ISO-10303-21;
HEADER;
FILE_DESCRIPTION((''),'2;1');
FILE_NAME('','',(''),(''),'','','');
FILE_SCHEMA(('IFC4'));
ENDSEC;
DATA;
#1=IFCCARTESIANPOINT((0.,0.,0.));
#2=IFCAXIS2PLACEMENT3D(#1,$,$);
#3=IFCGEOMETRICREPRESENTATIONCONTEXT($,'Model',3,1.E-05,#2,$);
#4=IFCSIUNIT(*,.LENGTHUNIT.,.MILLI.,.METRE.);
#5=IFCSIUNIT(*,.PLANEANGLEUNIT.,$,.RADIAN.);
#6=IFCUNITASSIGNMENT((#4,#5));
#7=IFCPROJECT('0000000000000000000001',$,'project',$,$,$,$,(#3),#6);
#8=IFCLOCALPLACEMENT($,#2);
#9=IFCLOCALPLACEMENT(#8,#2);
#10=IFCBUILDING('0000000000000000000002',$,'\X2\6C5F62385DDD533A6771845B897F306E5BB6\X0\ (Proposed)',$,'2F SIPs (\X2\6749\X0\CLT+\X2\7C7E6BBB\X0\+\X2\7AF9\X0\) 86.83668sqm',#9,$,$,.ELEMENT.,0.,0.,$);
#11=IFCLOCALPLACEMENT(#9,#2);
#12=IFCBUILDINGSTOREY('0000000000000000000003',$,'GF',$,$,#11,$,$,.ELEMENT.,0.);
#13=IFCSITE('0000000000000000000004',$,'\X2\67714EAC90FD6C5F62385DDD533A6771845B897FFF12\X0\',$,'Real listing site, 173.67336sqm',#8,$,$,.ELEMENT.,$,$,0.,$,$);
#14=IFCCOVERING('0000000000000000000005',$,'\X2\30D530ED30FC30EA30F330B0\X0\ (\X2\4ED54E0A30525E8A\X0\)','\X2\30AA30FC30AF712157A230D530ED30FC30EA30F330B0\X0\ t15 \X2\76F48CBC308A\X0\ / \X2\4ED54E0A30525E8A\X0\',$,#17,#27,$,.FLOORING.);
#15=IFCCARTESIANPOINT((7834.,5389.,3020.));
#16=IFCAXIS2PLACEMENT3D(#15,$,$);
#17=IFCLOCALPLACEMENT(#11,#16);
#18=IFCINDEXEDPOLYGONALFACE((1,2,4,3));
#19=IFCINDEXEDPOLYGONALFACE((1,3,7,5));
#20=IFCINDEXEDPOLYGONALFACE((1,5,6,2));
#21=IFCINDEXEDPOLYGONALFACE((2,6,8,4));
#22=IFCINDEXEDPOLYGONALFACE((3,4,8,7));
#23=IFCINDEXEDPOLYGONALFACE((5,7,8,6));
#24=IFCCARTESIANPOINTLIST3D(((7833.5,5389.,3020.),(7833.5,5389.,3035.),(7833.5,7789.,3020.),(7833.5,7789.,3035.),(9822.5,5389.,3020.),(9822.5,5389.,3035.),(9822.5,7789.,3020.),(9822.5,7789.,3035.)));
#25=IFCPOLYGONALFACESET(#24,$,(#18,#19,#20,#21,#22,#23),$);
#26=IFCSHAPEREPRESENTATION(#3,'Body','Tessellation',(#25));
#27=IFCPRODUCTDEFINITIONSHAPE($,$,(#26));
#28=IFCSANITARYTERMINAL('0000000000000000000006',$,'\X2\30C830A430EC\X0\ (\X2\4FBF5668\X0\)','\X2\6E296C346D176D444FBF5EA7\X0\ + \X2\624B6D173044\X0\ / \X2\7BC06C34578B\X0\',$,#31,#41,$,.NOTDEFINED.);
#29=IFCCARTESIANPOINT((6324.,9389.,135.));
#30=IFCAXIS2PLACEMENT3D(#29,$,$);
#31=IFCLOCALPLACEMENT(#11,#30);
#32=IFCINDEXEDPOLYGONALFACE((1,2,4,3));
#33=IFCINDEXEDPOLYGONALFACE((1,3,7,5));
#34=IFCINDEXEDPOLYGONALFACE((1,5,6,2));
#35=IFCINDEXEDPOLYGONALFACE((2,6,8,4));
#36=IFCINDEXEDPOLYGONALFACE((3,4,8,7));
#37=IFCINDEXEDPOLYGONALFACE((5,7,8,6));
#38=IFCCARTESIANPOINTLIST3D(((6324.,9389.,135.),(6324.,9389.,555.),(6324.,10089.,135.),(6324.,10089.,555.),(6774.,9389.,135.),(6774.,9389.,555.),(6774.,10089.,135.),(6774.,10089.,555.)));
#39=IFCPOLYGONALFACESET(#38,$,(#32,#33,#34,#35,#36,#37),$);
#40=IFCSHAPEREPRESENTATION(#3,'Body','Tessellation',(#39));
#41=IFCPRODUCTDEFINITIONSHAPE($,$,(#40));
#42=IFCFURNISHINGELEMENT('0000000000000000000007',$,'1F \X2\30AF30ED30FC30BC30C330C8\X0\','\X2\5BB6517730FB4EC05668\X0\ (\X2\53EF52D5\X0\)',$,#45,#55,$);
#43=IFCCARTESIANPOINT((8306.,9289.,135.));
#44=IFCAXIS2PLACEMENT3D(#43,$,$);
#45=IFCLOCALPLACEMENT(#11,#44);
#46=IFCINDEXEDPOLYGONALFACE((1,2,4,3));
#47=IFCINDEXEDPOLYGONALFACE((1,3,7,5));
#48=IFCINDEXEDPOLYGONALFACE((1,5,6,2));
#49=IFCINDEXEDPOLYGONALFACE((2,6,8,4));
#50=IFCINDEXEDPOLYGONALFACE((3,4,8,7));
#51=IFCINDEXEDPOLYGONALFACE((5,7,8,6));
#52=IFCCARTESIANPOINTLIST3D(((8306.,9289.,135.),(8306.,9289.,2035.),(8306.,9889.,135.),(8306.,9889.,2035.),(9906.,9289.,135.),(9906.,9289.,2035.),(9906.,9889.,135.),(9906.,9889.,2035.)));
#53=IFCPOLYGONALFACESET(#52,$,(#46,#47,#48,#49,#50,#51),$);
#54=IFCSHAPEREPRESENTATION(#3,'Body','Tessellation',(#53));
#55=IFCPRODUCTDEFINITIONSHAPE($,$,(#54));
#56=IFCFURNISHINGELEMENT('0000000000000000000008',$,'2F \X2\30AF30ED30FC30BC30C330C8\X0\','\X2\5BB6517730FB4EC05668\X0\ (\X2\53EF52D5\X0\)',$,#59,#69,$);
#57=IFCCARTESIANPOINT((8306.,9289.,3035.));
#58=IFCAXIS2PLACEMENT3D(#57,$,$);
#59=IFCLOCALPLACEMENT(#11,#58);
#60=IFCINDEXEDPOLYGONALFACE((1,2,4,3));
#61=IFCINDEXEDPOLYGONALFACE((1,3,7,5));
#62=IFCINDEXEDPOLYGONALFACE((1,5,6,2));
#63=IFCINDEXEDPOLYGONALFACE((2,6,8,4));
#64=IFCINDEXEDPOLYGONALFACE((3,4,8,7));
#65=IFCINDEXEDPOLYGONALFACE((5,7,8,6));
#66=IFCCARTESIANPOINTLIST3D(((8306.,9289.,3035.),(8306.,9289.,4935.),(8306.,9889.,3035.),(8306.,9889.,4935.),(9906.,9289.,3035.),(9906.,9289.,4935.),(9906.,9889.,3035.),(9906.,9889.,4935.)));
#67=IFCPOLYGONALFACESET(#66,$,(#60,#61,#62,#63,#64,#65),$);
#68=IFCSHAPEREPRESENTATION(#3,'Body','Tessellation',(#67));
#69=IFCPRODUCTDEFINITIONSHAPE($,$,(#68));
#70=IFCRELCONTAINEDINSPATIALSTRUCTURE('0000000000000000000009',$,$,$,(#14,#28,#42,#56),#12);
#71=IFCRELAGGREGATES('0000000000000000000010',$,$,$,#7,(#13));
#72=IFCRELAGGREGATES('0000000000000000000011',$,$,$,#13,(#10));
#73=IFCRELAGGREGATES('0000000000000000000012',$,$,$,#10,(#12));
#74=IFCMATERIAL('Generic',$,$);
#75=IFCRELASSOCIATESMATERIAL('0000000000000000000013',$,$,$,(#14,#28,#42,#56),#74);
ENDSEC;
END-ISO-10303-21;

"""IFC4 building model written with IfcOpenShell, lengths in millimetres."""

from ifc_helpers import new_model, si_unit, frame, frame_2d, origin, place, context, project, spatial, rectangle, extrude, material, element, save


model = new_model("IFC4")

# Units and contexts
model_context = context("Model", 3, precision=1e-05, world=origin())
ifc_project = project(units=[si_unit("LENGTHUNIT", "METRE", prefix="MILLI"), si_unit("PLANEANGLEUNIT", "RADIAN")], contexts=[model_context])

# Site, building, storey
site_placement = place(None, origin())
site = spatial("IfcSite", under=ifc_project, at=site_placement, Name="東京都江戸川区東葛西２", ObjectType="Real listing site, 173.67336sqm", CompositionType="ELEMENT", RefElevation=0.0)
building_placement = place(site_placement, origin())
building = spatial("IfcBuilding", under=site, at=building_placement, Name="江戸川区東葛西の家 (Proposed)", ObjectType="2F SIPs (杉CLT+籾殻+竹) 86.83668sqm", CompositionType="ELEMENT", ElevationOfRefHeight=0.0, ElevationOfTerrain=0.0)
storey_placement = place(building_placement, origin())
storey = spatial("IfcBuildingStorey", under=building, at=storey_placement, Name="GF", CompositionType="ELEMENT", Elevation=0.0)

# Covering
ifc_material_1 = material(Name="Generic")
covering_1_placement = place(storey_placement, frame((7834.0, 5389.0, 3020.0)))
element("IfcCovering", 1, at=covering_1_placement, inside=storey, material=ifc_material_1, Name="フローリング (仕上げ床)", Description="オーク無垢フローリング t15 直貼り / 仕上げ床", PredefinedType="FLOORING", context=model_context, shape_type="SweptSolid", body=[
    extrude(rectangle(XDim=1989.0, YDim=2400.0, at=frame_2d((994.0, 1200.0))), frame((7834.0, 5389.0, 3020.0)), (0.0, 0.0, 1.0), 15.0),
])

# Sanitary terminal
sanitary_terminal_placement = place(storey_placement, frame((6324.0, 9389.0, 135.0)))
element("IfcSanitaryTerminal", 2, at=sanitary_terminal_placement, inside=storey, material=ifc_material_1, Name="トイレ (便器)", Description="温水洗浄便座 + 手洗い / 節水型", PredefinedType="NOTDEFINED", context=model_context, shape_type="SweptSolid", body=[
    extrude(rectangle(XDim=450.0, YDim=700.0, at=frame_2d((225.0, 350.0))), frame((6324.0, 9389.0, 135.0)), (0.0, 0.0, 1.0), 420.0),
])

# Furnishing elements
furnishing_1_placement = place(storey_placement, frame((8306.0, 9289.0, 135.0)))
element("IfcFurnishingElement", 3, at=furnishing_1_placement, inside=storey, material=ifc_material_1, Name="1F クローゼット", Description="家具・什器 (可動)", context=model_context, shape_type="SweptSolid", body=[
    extrude(rectangle(XDim=1600.0, YDim=600.0, at=frame_2d((800.0, 300.0))), frame((8306.0, 9289.0, 135.0)), (0.0, 0.0, 1.0), 1900.0),
])
furnishing_2_placement = place(storey_placement, frame((8306.0, 9289.0, 3035.0)))
element("IfcFurnishingElement", 4, at=furnishing_2_placement, inside=storey, material=ifc_material_1, Name="2F クローゼット", Description="家具・什器 (可動)", context=model_context, shape_type="SweptSolid", body=[
    extrude(rectangle(XDim=1600.0, YDim=600.0, at=frame_2d((800.0, 300.0))), frame((8306.0, 9289.0, 3035.0)), (0.0, 0.0, 1.0), 1900.0),
])

save(model, "model.ifc")
